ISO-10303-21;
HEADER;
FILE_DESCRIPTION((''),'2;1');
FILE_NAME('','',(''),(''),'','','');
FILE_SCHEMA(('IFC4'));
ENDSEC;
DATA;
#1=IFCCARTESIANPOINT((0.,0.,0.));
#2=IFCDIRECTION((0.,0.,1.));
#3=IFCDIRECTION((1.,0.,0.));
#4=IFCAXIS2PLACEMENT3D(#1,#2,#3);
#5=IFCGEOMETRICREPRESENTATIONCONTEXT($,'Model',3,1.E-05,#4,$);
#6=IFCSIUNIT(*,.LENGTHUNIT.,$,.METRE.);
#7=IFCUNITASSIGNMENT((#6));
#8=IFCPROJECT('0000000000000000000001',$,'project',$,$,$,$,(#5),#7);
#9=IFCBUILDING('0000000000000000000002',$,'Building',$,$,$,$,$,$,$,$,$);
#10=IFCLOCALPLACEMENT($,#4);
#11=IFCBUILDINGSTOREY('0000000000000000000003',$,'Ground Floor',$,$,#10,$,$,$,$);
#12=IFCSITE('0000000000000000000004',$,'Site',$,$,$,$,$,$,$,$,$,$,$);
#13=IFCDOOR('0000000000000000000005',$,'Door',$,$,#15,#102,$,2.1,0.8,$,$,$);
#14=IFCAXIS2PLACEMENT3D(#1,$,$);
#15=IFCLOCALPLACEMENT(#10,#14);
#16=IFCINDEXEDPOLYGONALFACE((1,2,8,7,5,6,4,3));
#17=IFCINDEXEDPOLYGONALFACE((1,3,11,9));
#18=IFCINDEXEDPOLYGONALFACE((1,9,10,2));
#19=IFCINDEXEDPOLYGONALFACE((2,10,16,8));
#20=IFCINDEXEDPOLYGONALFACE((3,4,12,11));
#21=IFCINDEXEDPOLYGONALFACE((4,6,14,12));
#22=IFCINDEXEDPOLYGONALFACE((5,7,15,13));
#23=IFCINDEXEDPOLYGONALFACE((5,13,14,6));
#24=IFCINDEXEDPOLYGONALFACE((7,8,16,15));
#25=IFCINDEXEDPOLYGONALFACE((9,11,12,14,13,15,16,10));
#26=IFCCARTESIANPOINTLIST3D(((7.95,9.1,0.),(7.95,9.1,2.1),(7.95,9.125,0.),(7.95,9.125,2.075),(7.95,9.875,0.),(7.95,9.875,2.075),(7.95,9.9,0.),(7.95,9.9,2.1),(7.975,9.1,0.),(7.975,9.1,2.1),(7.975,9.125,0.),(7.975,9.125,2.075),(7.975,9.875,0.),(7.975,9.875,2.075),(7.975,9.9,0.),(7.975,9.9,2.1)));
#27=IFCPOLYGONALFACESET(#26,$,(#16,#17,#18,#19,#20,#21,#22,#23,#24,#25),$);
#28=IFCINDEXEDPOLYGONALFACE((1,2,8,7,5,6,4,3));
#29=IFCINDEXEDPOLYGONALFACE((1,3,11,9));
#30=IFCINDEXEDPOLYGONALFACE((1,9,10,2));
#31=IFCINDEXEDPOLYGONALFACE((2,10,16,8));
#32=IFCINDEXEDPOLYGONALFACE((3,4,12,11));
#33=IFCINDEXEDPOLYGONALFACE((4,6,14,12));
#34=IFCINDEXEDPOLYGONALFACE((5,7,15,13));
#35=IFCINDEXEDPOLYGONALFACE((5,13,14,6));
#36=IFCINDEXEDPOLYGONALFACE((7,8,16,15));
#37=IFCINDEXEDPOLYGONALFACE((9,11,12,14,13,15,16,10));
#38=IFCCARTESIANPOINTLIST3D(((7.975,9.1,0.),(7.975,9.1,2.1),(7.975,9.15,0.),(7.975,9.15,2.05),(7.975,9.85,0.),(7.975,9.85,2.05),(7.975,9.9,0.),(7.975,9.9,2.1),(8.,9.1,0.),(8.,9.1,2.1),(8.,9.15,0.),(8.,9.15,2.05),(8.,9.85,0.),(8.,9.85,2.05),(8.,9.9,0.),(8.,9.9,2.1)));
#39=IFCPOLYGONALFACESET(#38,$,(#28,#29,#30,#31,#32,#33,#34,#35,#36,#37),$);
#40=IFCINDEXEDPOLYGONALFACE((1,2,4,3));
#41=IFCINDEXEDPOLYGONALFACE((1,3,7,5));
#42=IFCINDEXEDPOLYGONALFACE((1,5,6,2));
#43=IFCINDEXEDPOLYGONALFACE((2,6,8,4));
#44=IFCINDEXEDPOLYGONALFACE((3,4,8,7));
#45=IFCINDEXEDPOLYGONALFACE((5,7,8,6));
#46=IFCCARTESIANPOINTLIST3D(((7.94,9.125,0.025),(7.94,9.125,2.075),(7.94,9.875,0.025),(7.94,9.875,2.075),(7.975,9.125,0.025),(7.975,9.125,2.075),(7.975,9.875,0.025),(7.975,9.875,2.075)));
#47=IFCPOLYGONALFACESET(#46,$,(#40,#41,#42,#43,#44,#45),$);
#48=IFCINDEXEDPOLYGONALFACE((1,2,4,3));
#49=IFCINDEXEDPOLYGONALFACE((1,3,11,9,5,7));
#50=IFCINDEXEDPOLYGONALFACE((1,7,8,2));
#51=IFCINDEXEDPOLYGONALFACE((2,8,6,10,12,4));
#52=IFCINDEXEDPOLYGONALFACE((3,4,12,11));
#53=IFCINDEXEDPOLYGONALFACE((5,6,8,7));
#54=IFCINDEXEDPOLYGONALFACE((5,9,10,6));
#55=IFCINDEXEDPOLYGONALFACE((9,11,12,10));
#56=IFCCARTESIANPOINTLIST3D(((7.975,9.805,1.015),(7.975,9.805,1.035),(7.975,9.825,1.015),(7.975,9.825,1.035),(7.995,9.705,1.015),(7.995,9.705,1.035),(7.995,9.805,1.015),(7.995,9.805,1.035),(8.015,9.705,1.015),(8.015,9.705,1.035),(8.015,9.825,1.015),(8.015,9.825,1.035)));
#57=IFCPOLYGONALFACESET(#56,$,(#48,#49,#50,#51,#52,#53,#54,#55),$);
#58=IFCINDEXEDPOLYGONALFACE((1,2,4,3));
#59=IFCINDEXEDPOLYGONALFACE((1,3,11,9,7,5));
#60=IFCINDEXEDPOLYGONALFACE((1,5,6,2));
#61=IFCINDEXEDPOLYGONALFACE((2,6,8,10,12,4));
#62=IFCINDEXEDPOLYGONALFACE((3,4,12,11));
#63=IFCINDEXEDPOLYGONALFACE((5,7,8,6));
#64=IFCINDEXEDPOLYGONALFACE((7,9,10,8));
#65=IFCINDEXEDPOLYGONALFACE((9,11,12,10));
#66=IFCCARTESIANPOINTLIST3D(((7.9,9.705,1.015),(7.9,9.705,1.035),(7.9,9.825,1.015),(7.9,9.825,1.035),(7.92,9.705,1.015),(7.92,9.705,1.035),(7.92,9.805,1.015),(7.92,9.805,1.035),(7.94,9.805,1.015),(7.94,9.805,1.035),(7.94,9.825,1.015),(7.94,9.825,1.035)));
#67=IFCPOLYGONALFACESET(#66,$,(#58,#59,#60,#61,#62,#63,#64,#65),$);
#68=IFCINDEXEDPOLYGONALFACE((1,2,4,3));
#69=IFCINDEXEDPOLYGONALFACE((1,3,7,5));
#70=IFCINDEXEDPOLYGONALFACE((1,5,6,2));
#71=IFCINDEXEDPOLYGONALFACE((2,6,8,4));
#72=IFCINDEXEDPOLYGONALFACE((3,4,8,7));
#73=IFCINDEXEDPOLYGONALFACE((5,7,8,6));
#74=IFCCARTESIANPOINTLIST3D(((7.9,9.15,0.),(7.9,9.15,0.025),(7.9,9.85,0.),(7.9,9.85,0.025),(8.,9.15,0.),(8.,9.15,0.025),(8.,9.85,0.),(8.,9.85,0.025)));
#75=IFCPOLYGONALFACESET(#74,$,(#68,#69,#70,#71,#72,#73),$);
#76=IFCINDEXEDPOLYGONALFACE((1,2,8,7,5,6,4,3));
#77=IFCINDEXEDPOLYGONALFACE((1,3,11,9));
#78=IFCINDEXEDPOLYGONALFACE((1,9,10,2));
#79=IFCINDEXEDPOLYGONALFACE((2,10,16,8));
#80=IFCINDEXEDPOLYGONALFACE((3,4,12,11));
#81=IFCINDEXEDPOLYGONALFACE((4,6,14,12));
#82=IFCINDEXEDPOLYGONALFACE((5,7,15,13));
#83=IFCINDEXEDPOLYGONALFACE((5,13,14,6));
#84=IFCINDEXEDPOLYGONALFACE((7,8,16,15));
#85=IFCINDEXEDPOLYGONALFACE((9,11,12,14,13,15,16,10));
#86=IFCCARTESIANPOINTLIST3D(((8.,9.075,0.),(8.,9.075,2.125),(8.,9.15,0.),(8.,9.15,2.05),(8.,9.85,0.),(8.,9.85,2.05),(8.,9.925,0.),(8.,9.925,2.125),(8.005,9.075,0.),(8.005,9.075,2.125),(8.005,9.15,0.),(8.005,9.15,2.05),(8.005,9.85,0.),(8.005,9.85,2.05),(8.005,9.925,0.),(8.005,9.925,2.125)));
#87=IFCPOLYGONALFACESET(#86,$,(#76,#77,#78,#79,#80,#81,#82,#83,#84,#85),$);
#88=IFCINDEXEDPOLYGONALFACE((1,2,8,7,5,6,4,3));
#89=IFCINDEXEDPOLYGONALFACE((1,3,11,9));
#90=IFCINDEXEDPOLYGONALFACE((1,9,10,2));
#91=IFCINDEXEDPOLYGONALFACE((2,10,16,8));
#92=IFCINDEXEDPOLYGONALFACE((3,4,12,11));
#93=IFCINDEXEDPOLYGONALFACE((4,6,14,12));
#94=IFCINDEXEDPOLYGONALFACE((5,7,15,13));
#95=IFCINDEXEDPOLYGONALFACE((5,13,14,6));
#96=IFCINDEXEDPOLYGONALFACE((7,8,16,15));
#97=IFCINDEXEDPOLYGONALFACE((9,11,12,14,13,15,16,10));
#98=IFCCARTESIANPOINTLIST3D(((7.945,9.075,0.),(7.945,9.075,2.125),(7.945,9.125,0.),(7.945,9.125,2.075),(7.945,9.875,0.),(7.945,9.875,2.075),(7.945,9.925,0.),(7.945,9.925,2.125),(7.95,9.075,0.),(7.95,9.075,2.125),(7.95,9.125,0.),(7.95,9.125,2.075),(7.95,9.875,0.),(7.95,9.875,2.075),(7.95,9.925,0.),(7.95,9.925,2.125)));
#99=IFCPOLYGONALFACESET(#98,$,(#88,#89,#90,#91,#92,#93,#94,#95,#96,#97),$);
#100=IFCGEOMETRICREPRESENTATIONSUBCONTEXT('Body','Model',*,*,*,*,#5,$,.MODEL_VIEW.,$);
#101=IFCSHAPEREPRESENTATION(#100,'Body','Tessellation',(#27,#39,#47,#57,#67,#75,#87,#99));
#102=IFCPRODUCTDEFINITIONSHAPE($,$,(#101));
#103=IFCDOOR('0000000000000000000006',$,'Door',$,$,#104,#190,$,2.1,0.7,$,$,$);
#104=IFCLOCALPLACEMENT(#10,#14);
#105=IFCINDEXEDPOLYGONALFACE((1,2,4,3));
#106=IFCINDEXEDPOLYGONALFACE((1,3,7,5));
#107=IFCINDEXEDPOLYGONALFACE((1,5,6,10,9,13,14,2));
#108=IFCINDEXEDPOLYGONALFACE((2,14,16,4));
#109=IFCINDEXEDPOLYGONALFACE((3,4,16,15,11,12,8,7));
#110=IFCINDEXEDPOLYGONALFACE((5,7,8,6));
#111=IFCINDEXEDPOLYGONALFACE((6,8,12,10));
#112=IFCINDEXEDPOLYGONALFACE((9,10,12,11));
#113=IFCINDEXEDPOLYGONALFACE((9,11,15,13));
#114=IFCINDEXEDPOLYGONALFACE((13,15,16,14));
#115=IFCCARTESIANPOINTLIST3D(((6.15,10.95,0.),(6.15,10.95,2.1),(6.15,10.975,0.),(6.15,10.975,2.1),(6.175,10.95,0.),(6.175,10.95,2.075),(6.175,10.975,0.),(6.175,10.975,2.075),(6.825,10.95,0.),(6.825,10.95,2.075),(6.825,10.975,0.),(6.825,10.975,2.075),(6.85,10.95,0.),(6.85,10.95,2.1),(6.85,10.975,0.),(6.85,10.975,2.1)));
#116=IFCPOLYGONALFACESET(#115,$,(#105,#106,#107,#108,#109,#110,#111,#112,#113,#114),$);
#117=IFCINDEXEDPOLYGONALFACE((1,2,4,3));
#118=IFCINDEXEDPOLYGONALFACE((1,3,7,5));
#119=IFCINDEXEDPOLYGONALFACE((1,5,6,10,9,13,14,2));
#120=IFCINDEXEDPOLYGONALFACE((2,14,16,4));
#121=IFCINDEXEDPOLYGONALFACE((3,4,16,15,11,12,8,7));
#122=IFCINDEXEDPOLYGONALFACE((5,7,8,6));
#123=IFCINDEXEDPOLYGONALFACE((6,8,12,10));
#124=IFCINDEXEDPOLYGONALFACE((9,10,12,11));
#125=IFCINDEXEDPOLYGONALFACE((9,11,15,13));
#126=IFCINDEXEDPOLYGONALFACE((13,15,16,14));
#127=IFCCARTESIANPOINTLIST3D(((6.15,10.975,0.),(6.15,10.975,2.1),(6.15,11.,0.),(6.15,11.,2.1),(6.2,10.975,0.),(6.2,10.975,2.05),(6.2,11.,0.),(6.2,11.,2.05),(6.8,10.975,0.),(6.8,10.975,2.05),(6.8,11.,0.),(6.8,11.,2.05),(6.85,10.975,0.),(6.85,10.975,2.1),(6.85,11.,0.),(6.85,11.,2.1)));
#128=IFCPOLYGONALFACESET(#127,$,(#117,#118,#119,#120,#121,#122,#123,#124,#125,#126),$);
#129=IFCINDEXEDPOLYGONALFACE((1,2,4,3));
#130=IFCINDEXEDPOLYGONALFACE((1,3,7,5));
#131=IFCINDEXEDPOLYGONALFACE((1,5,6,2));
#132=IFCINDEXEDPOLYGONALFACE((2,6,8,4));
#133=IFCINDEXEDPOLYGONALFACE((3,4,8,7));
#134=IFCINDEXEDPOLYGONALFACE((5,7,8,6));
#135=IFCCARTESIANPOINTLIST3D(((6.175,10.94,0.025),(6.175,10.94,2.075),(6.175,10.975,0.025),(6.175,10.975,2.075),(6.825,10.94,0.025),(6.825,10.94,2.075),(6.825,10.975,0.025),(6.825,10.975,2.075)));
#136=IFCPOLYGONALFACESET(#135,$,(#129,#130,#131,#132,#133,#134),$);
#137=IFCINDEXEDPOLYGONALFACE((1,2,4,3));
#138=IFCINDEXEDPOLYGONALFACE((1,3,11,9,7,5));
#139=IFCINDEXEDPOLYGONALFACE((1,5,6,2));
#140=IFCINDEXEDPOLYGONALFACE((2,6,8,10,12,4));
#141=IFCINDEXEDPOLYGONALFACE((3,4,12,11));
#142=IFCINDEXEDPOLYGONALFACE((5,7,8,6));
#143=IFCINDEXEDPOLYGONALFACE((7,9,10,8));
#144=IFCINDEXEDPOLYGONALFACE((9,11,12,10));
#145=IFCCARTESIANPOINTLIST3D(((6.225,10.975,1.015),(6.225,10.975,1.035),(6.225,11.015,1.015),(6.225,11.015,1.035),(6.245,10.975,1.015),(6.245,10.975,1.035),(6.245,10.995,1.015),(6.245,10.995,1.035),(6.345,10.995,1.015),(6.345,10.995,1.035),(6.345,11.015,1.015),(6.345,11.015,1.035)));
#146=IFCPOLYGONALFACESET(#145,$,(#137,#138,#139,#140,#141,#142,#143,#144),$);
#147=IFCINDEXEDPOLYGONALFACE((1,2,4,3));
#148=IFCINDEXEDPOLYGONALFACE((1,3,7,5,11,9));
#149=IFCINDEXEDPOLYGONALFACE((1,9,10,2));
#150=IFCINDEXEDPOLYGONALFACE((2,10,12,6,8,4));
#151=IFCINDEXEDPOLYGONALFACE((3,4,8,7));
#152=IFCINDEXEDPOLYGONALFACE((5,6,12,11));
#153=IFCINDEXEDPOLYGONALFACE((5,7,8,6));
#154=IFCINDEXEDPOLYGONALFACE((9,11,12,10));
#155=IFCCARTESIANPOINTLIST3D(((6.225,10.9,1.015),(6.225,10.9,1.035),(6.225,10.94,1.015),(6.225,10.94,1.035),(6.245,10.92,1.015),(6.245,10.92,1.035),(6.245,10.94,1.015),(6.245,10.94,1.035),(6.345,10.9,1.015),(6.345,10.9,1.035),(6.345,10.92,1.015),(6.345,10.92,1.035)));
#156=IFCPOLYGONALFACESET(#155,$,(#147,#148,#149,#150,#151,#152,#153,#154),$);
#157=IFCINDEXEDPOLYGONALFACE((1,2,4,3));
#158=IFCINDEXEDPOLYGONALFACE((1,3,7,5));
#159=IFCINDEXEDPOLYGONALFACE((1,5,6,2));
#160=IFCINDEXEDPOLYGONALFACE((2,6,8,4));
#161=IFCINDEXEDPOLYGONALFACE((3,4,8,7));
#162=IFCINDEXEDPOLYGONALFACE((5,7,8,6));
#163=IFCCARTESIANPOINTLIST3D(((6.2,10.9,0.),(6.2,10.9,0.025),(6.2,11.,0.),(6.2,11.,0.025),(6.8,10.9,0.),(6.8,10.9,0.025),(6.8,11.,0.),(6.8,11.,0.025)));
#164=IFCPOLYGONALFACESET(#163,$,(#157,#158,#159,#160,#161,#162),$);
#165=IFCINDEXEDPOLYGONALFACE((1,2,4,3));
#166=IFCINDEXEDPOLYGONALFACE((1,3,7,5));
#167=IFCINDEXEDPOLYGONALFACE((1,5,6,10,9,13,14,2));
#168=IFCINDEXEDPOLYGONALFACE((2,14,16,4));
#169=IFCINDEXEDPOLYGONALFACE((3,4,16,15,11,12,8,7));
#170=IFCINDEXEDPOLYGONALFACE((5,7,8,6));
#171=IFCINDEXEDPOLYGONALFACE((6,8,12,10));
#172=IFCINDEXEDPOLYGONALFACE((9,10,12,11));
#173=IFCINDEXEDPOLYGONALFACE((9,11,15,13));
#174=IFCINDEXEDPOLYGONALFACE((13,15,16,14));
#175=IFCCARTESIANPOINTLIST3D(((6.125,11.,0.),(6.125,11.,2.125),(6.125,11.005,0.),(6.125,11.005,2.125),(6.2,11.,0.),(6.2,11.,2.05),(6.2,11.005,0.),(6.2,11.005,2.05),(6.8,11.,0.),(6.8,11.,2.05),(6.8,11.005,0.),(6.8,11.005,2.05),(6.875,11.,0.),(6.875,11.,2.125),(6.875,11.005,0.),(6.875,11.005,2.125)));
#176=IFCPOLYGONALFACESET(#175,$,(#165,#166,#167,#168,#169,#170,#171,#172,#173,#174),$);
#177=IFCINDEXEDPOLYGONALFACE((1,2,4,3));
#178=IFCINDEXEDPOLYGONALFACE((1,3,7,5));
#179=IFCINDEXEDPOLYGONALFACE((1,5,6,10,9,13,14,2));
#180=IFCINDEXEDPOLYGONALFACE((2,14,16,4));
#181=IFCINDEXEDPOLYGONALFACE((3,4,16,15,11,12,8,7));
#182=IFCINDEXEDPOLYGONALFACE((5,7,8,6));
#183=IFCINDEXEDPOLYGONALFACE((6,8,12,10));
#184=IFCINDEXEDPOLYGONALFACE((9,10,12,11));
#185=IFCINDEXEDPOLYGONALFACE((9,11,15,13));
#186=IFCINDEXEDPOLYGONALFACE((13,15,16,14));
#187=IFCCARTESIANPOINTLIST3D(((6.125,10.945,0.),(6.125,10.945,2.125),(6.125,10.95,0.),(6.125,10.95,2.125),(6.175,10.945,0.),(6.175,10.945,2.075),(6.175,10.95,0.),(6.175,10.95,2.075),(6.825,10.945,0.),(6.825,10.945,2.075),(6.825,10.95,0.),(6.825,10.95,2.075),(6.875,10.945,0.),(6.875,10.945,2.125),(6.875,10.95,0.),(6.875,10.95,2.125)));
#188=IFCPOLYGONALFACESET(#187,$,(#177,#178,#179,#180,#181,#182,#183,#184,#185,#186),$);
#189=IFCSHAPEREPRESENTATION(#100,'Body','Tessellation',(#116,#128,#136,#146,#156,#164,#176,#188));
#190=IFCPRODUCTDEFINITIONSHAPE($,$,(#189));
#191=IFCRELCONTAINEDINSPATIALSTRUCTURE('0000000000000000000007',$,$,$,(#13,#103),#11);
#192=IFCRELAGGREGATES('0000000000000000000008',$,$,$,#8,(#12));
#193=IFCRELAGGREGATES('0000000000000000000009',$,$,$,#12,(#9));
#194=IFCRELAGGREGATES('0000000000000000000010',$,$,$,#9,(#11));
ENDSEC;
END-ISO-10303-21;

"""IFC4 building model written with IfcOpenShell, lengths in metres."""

from ifc_helpers import new_model, si_unit, frame, origin_with_axes, place, context, subcontext, project, spatial, line, indexed_curve, outline, extrude, element, save


model = new_model("IFC4")

# Units and contexts
model_context = context("Model", 3, precision=1e-05, world=origin_with_axes())
body_context = subcontext(model_context, "Body", "Model", "MODEL_VIEW")
ifc_project = project(units=[si_unit("LENGTHUNIT", "METRE")], contexts=[model_context])

# Site, building, storey
site = spatial("IfcSite", under=ifc_project, Name="Site")
building = spatial("IfcBuilding", under=site, Name="Building")
storey_placement = place(None, origin_with_axes())
storey = spatial("IfcBuildingStorey", under=building, at=storey_placement, Name="Ground Floor")

# Doors
door_1_placement = place(storey_placement, frame((8.0, 9.1, 0.0), z_axis=(0.0, 0.0, 1.0), x_axis=(0.0, 1.0, 0.0)))
element("IfcDoor", 1, at=door_1_placement, inside=storey, Name="Door", OverallHeight=2.1, OverallWidth=0.8, context=body_context, shape_type="SweptSolid", body=[
    extrude(outline(indexed_curve([(0.0, 0.0), (0.0, 2.1), (0.8, 2.1), (0.8, 0.0), (0.775, 0.0), (0.775, 2.075), (0.025, 2.075), (0.025, 0.0)], segments=[line(1, 2, 3, 4, 5, 6, 7, 8, 1)])), frame((0.0, 0.025, 0.0), z_axis=(0.0, -1.0, 0.0), x_axis=(1.0, 0.0, 0.0)), (0.0, 0.0, -1.0), 0.025),
    extrude(outline(indexed_curve([(0.0, 0.0), (0.0, 2.1), (0.8, 2.1), (0.8, 0.0), (0.75, 0.0), (0.75, 2.05), (0.05, 2.05), (0.05, 0.0)], segments=[line(1, 2, 3, 4, 5, 6, 7, 8, 1)])), frame((0.0, 0.0, 0.0), z_axis=(0.0, -1.0, 0.0), x_axis=(1.0, 0.0, 0.0)), (0.0, 0.0, -1.0), 0.025),
    extrude(outline(indexed_curve([(0.0, 0.0), (0.75, 0.0), (0.75, 0.035), (0.0, 0.035)], segments=[line(1, 2, 3, 4, 1)])), frame((0.025, 0.025, 0.025), z_axis=(0.0, 0.0, 1.0), x_axis=(1.0, 0.0, 0.0)), (0.0, 0.0, 1.0), 2.05),
    extrude(outline(indexed_curve([(0.0, 0.0), (0.0, -0.04), (-0.12, -0.04), (-0.12, -0.02), (-0.02, -0.02), (-0.02, 0.0)], segments=[line(1, 2, 3, 4, 5, 6, 1)])), frame((0.725, 0.025, 1.015), z_axis=(0.0, 0.0, 1.0), x_axis=(1.0, 0.0, 0.0)), (0.0, 0.0, 1.0), 0.02),
    extrude(outline(indexed_curve([(0.0, 0.0), (0.0, 0.04), (-0.12, 0.04), (-0.12, 0.02), (-0.02, 0.02), (-0.02, 0.0)], segments=[line(1, 2, 3, 4, 5, 6, 1)])), frame((0.725, 0.06, 1.015), z_axis=(0.0, 0.0, 1.0), x_axis=(1.0, 0.0, 0.0)), (0.0, 0.0, 1.0), 0.02),
    extrude(outline(indexed_curve([(0.0, 0.0), (0.7, 0.0), (0.7, 0.1), (0.0, 0.1)], segments=[line(1, 2, 3, 4, 1)])), frame((0.05, 0.0, 0.0), z_axis=(0.0, 0.0, 1.0), x_axis=(1.0, 0.0, 0.0)), (0.0, 0.0, 1.0), 0.025),
    extrude(outline(indexed_curve([(0.0, 0.0), (0.0, 2.125), (0.85, 2.125), (0.85, 0.0), (0.775, 0.0), (0.775, 2.05), (0.075, 2.05), (0.075, 0.0)], segments=[line(1, 2, 3, 4, 5, 6, 7, 8, 1)])), frame((-0.025, -0.005, 0.0), z_axis=(0.0, -1.0, 0.0), x_axis=(1.0, 0.0, 0.0)), (0.0, 0.0, -1.0), 0.005),
    extrude(outline(indexed_curve([(0.0, 0.0), (0.0, 2.125), (0.85, 2.125), (0.85, 0.0), (0.8, 0.0), (0.8, 2.075), (0.05, 2.075), (0.05, 0.0)], segments=[line(1, 2, 3, 4, 5, 6, 7, 8, 1)])), frame((-0.025, 0.05, 0.0), z_axis=(0.0, -1.0, 0.0), x_axis=(1.0, 0.0, 0.0)), (0.0, 0.0, -1.0), 0.005),
])
door_2_placement = place(storey_placement, frame((6.85, 11.0, 0.0), z_axis=(0.0, 0.0, 1.0), x_axis=(-1.0, 0.0, 0.0)))
element("IfcDoor", 2, at=door_2_placement, inside=storey, Name="Door", OverallHeight=2.1, OverallWidth=0.7, context=body_context, shape_type="SweptSolid", body=[
    extrude(outline(indexed_curve([(0.0, 0.0), (0.0, 2.1), (0.7, 2.1), (0.7, 0.0), (0.675, 0.0), (0.675, 2.075), (0.025, 2.075), (0.025, 0.0)], segments=[line(1, 2, 3, 4, 5, 6, 7, 8, 1)])), frame((0.0, 0.025, 0.0), z_axis=(0.0, -1.0, 0.0), x_axis=(1.0, 0.0, 0.0)), (0.0, 0.0, -1.0), 0.025),
    extrude(outline(indexed_curve([(0.0, 0.0), (0.0, 2.1), (0.7, 2.1), (0.7, 0.0), (0.65, 0.0), (0.65, 2.05), (0.05, 2.05), (0.05, 0.0)], segments=[line(1, 2, 3, 4, 5, 6, 7, 8, 1)])), frame((0.0, 0.0, 0.0), z_axis=(0.0, -1.0, 0.0), x_axis=(1.0, 0.0, 0.0)), (0.0, 0.0, -1.0), 0.025),
    extrude(outline(indexed_curve([(0.0, 0.0), (0.65, 0.0), (0.65, 0.035), (0.0, 0.035)], segments=[line(1, 2, 3, 4, 1)])), frame((0.025, 0.025, 0.025), z_axis=(0.0, 0.0, 1.0), x_axis=(1.0, 0.0, 0.0)), (0.0, 0.0, 1.0), 2.05),
    extrude(outline(indexed_curve([(0.0, 0.0), (0.0, -0.04), (-0.12, -0.04), (-0.12, -0.02), (-0.02, -0.02), (-0.02, 0.0)], segments=[line(1, 2, 3, 4, 5, 6, 1)])), frame((0.625, 0.025, 1.015), z_axis=(0.0, 0.0, 1.0), x_axis=(1.0, 0.0, 0.0)), (0.0, 0.0, 1.0), 0.02),
    extrude(outline(indexed_curve([(0.0, 0.0), (0.0, 0.04), (-0.12, 0.04), (-0.12, 0.02), (-0.02, 0.02), (-0.02, 0.0)], segments=[line(1, 2, 3, 4, 5, 6, 1)])), frame((0.625, 0.06, 1.015), z_axis=(0.0, 0.0, 1.0), x_axis=(1.0, 0.0, 0.0)), (0.0, 0.0, 1.0), 0.02),
    extrude(outline(indexed_curve([(0.0, 0.0), (0.6, 0.0), (0.6, 0.1), (0.0, 0.1)], segments=[line(1, 2, 3, 4, 1)])), frame((0.05, 0.0, 0.0), z_axis=(0.0, 0.0, 1.0), x_axis=(1.0, 0.0, 0.0)), (0.0, 0.0, 1.0), 0.025),
    extrude(outline(indexed_curve([(0.0, 0.0), (0.0, 2.125), (0.75, 2.125), (0.75, 0.0), (0.675, 0.0), (0.675, 2.05), (0.075, 2.05), (0.075, 0.0)], segments=[line(1, 2, 3, 4, 5, 6, 7, 8, 1)])), frame((-0.025, -0.005, 0.0), z_axis=(0.0, -1.0, 0.0), x_axis=(1.0, 0.0, 0.0)), (0.0, 0.0, -1.0), 0.005),
    extrude(outline(indexed_curve([(0.0, 0.0), (0.0, 2.125), (0.75, 2.125), (0.75, 0.0), (0.7, 0.0), (0.7, 2.075), (0.05, 2.075), (0.05, 0.0)], segments=[line(1, 2, 3, 4, 5, 6, 7, 8, 1)])), frame((-0.025, 0.05, 0.0), z_axis=(0.0, -1.0, 0.0), x_axis=(1.0, 0.0, 0.0)), (0.0, 0.0, -1.0), 0.005),
])

save(model, "model.ifc")
